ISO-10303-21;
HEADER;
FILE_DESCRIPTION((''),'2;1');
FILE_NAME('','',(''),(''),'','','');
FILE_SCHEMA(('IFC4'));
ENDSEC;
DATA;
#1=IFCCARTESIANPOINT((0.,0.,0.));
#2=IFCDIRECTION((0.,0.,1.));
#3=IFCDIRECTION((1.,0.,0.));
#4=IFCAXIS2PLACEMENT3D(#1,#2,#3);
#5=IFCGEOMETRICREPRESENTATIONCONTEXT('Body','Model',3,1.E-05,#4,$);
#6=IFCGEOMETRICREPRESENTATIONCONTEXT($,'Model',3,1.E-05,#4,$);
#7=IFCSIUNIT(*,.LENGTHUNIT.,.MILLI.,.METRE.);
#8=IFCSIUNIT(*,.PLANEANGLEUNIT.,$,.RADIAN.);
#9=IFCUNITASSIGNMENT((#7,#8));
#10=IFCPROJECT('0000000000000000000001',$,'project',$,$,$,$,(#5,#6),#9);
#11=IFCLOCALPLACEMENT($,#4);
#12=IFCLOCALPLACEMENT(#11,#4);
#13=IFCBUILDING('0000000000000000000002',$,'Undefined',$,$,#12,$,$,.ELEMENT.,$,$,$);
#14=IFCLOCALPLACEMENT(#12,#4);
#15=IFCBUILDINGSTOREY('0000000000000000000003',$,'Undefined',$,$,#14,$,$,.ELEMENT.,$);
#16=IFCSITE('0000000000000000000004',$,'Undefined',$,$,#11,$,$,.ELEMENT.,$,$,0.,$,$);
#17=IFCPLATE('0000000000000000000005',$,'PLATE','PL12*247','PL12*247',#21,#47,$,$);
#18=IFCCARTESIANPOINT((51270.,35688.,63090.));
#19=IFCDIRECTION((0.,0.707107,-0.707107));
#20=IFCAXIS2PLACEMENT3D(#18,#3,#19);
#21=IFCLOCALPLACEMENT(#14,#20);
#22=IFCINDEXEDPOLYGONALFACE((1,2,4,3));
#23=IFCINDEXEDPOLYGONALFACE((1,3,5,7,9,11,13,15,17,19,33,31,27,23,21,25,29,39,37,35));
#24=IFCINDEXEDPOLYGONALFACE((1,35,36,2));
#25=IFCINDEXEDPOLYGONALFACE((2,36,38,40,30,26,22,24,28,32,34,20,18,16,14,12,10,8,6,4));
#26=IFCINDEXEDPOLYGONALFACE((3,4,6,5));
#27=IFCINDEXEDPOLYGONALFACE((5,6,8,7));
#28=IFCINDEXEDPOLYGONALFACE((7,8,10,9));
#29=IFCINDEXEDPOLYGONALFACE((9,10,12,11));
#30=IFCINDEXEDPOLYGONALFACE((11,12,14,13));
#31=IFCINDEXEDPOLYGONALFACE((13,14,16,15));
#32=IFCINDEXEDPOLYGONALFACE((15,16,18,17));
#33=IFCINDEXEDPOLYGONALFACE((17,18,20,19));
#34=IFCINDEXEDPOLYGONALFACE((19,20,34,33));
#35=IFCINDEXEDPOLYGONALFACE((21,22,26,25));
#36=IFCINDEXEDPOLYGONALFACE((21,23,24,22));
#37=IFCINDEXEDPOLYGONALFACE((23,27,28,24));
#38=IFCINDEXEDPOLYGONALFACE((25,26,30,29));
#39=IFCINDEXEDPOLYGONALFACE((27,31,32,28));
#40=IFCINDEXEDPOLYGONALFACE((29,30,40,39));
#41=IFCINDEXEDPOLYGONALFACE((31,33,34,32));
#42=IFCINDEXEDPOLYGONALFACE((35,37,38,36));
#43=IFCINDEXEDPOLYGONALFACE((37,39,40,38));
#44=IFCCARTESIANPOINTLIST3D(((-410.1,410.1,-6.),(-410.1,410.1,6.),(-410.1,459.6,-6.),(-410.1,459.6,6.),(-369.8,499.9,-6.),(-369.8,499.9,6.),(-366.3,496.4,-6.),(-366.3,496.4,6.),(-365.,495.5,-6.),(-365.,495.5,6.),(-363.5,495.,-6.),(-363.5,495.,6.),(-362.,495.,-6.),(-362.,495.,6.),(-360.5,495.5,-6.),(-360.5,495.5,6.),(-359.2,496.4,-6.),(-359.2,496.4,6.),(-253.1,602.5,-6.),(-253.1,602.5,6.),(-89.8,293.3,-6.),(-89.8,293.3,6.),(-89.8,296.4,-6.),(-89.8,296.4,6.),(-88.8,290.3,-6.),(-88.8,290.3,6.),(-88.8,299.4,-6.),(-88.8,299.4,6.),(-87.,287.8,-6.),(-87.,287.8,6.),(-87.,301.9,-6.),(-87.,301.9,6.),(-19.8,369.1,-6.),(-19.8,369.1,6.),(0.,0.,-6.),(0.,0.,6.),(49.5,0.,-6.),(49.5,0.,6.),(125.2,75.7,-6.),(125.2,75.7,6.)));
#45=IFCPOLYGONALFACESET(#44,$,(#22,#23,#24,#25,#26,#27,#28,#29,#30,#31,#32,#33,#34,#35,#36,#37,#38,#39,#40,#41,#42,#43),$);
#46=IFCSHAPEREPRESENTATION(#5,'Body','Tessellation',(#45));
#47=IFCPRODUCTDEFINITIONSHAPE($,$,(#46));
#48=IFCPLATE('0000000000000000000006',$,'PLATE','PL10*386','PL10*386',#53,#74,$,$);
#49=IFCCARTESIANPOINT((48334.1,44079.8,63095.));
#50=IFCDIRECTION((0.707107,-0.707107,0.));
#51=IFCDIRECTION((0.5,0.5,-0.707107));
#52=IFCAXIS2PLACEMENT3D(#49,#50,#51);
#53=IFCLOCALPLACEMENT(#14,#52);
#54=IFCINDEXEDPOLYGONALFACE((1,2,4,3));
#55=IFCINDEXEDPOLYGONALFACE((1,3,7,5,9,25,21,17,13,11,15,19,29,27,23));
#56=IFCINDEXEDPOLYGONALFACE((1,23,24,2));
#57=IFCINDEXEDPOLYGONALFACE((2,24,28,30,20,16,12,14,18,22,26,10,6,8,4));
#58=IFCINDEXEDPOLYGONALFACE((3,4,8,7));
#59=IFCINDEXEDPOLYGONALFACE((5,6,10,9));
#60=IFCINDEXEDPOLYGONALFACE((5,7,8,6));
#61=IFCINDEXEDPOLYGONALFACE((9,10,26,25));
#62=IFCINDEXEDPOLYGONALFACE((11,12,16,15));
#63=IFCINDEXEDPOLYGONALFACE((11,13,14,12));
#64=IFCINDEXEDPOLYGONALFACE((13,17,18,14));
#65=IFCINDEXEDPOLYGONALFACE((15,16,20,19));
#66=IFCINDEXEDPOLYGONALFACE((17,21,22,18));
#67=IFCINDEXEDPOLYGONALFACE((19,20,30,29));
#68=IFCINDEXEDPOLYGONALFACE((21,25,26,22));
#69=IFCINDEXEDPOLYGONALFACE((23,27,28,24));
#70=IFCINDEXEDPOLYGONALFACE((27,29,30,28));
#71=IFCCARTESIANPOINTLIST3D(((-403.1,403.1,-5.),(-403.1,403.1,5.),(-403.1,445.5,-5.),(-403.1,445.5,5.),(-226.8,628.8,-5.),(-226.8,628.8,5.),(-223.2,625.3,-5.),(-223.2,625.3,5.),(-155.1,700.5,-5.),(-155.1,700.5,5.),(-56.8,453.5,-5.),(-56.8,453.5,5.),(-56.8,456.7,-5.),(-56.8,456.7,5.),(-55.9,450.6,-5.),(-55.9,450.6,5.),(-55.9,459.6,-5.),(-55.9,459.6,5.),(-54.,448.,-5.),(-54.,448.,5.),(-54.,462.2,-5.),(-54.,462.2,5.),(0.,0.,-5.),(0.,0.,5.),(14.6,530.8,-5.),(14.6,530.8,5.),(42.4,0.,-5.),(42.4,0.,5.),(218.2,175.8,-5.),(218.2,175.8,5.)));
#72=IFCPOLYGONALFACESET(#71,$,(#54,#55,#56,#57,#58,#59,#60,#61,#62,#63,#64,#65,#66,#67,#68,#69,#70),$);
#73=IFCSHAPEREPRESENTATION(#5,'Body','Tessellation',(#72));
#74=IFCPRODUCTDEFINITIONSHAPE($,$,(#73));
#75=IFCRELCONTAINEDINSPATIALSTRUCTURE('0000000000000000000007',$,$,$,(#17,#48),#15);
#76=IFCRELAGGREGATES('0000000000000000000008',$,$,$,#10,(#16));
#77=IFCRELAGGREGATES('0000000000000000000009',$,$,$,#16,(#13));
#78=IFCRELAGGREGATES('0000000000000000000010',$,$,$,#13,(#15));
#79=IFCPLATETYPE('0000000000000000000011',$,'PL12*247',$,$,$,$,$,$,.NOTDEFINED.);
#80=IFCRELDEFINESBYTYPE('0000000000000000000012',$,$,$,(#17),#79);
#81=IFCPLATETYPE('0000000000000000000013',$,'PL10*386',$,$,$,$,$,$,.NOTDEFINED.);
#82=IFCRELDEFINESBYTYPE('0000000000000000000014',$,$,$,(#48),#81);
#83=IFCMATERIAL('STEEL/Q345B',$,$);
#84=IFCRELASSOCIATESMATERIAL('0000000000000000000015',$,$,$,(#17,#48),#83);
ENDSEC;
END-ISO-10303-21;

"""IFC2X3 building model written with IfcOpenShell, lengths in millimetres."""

from ifc_helpers import new_model, si_unit, frame, origin_with_axes, place, context, project, spatial, polyline, outline, extrude, material, type_object, element, save


model = new_model("IFC2X3")

# Units and contexts
model_context_1 = context("Model", 3, precision=1e-05, world=origin_with_axes(), identifier="Body")
model_context_2 = context("Model", 3, precision=1e-05, world=origin_with_axes())
ifc_project = project(units=[si_unit("LENGTHUNIT", "METRE", prefix="MILLI"), si_unit("PLANEANGLEUNIT", "RADIAN")], contexts=[model_context_1, model_context_2])

# Site, building, storey
site_placement = place(None, origin_with_axes())
site = spatial("IfcSite", under=ifc_project, at=site_placement, Name="Undefined", CompositionType="ELEMENT", RefElevation=0.0)
building_placement = place(site_placement, origin_with_axes())
building = spatial("IfcBuilding", under=site, at=building_placement, Name="Undefined", CompositionType="ELEMENT")
storey_placement = place(building_placement, origin_with_axes())
storey = spatial("IfcBuildingStorey", under=building, at=storey_placement, Name="Undefined", CompositionType="ELEMENT")

# Shared definitions
ifc_material_1 = material(Name="STEEL/Q345B")

# Plates
plate_type_1 = type_object("IfcPlateType", Name="PL12*247", PredefinedType="NOTDEFINED")
for number, where, z_axis, x_axis, name in (
    (1, (51270.0, 35688.0, 63090.0), (1.0, 0.0, 0.0), (0.0, 0.707107, -0.707107), "PLATE"),
):
    element("IfcPlate", number, at=place(storey_placement, frame(where, z_axis=z_axis, x_axis=x_axis)), inside=storey, type_object=plate_type_1, material=ifc_material_1, Name=name, Description="PL12*247", ObjectType="PL12*247", context=model_context_1, shape_type="SweptSolid", body=[
        extrude(outline(polyline([(0.0, 0.0), (49.5, 0.0), (125.2, 75.7), (-87.0, 287.8), (-88.8, 290.3), (-89.8, 293.3), (-89.8, 296.4), (-88.8, 299.4), (-87.0, 301.9), (-19.8, 369.1), (-253.1, 602.5), (-359.2, 496.4), (-360.5, 495.5), (-362.0, 495.0), (-363.5, 495.0), (-365.0, 495.5), (-366.3, 496.4), (-369.8, 499.9), (-410.1, 459.6), (-410.1, 410.1), (0.0, 0.0)])), frame((0.0, 0.0, -6.0), z_axis=(0.0, 0.0, 1.0), x_axis=(1.0, 0.0, 0.0)), (0.0, 0.0, 1.0), 12.0),
    ])
plate_type_2 = type_object("IfcPlateType", Name="PL10*386", PredefinedType="NOTDEFINED")
plate_1_placement = place(storey_placement, frame((48334.1, 44079.8, 63095.0), z_axis=(0.707107, -0.707107, 0.0), x_axis=(0.5, 0.5, -0.707107)))
element("IfcPlate", 2, at=plate_1_placement, inside=storey, type_object=plate_type_2, material=ifc_material_1, Name="PLATE", Description="PL10*386", ObjectType="PL10*386", context=model_context_1, shape_type="SweptSolid", body=[
    extrude(outline(polyline([(0.0, 0.0), (42.4, 0.0), (218.2, 175.8), (-54.0, 448.0), (-55.9, 450.6), (-56.8, 453.5), (-56.8, 456.7), (-55.9, 459.6), (-54.0, 462.2), (14.6, 530.8), (-155.1, 700.5), (-226.8, 628.8), (-223.2, 625.3), (-403.1, 445.5), (-403.1, 403.1), (0.0, 0.0)])), frame((0.0, 0.0, -5.0), z_axis=(0.0, 0.0, 1.0), x_axis=(1.0, 0.0, 0.0)), (0.0, 0.0, 1.0), 10.0),
])

save(model, "model.ifc")
